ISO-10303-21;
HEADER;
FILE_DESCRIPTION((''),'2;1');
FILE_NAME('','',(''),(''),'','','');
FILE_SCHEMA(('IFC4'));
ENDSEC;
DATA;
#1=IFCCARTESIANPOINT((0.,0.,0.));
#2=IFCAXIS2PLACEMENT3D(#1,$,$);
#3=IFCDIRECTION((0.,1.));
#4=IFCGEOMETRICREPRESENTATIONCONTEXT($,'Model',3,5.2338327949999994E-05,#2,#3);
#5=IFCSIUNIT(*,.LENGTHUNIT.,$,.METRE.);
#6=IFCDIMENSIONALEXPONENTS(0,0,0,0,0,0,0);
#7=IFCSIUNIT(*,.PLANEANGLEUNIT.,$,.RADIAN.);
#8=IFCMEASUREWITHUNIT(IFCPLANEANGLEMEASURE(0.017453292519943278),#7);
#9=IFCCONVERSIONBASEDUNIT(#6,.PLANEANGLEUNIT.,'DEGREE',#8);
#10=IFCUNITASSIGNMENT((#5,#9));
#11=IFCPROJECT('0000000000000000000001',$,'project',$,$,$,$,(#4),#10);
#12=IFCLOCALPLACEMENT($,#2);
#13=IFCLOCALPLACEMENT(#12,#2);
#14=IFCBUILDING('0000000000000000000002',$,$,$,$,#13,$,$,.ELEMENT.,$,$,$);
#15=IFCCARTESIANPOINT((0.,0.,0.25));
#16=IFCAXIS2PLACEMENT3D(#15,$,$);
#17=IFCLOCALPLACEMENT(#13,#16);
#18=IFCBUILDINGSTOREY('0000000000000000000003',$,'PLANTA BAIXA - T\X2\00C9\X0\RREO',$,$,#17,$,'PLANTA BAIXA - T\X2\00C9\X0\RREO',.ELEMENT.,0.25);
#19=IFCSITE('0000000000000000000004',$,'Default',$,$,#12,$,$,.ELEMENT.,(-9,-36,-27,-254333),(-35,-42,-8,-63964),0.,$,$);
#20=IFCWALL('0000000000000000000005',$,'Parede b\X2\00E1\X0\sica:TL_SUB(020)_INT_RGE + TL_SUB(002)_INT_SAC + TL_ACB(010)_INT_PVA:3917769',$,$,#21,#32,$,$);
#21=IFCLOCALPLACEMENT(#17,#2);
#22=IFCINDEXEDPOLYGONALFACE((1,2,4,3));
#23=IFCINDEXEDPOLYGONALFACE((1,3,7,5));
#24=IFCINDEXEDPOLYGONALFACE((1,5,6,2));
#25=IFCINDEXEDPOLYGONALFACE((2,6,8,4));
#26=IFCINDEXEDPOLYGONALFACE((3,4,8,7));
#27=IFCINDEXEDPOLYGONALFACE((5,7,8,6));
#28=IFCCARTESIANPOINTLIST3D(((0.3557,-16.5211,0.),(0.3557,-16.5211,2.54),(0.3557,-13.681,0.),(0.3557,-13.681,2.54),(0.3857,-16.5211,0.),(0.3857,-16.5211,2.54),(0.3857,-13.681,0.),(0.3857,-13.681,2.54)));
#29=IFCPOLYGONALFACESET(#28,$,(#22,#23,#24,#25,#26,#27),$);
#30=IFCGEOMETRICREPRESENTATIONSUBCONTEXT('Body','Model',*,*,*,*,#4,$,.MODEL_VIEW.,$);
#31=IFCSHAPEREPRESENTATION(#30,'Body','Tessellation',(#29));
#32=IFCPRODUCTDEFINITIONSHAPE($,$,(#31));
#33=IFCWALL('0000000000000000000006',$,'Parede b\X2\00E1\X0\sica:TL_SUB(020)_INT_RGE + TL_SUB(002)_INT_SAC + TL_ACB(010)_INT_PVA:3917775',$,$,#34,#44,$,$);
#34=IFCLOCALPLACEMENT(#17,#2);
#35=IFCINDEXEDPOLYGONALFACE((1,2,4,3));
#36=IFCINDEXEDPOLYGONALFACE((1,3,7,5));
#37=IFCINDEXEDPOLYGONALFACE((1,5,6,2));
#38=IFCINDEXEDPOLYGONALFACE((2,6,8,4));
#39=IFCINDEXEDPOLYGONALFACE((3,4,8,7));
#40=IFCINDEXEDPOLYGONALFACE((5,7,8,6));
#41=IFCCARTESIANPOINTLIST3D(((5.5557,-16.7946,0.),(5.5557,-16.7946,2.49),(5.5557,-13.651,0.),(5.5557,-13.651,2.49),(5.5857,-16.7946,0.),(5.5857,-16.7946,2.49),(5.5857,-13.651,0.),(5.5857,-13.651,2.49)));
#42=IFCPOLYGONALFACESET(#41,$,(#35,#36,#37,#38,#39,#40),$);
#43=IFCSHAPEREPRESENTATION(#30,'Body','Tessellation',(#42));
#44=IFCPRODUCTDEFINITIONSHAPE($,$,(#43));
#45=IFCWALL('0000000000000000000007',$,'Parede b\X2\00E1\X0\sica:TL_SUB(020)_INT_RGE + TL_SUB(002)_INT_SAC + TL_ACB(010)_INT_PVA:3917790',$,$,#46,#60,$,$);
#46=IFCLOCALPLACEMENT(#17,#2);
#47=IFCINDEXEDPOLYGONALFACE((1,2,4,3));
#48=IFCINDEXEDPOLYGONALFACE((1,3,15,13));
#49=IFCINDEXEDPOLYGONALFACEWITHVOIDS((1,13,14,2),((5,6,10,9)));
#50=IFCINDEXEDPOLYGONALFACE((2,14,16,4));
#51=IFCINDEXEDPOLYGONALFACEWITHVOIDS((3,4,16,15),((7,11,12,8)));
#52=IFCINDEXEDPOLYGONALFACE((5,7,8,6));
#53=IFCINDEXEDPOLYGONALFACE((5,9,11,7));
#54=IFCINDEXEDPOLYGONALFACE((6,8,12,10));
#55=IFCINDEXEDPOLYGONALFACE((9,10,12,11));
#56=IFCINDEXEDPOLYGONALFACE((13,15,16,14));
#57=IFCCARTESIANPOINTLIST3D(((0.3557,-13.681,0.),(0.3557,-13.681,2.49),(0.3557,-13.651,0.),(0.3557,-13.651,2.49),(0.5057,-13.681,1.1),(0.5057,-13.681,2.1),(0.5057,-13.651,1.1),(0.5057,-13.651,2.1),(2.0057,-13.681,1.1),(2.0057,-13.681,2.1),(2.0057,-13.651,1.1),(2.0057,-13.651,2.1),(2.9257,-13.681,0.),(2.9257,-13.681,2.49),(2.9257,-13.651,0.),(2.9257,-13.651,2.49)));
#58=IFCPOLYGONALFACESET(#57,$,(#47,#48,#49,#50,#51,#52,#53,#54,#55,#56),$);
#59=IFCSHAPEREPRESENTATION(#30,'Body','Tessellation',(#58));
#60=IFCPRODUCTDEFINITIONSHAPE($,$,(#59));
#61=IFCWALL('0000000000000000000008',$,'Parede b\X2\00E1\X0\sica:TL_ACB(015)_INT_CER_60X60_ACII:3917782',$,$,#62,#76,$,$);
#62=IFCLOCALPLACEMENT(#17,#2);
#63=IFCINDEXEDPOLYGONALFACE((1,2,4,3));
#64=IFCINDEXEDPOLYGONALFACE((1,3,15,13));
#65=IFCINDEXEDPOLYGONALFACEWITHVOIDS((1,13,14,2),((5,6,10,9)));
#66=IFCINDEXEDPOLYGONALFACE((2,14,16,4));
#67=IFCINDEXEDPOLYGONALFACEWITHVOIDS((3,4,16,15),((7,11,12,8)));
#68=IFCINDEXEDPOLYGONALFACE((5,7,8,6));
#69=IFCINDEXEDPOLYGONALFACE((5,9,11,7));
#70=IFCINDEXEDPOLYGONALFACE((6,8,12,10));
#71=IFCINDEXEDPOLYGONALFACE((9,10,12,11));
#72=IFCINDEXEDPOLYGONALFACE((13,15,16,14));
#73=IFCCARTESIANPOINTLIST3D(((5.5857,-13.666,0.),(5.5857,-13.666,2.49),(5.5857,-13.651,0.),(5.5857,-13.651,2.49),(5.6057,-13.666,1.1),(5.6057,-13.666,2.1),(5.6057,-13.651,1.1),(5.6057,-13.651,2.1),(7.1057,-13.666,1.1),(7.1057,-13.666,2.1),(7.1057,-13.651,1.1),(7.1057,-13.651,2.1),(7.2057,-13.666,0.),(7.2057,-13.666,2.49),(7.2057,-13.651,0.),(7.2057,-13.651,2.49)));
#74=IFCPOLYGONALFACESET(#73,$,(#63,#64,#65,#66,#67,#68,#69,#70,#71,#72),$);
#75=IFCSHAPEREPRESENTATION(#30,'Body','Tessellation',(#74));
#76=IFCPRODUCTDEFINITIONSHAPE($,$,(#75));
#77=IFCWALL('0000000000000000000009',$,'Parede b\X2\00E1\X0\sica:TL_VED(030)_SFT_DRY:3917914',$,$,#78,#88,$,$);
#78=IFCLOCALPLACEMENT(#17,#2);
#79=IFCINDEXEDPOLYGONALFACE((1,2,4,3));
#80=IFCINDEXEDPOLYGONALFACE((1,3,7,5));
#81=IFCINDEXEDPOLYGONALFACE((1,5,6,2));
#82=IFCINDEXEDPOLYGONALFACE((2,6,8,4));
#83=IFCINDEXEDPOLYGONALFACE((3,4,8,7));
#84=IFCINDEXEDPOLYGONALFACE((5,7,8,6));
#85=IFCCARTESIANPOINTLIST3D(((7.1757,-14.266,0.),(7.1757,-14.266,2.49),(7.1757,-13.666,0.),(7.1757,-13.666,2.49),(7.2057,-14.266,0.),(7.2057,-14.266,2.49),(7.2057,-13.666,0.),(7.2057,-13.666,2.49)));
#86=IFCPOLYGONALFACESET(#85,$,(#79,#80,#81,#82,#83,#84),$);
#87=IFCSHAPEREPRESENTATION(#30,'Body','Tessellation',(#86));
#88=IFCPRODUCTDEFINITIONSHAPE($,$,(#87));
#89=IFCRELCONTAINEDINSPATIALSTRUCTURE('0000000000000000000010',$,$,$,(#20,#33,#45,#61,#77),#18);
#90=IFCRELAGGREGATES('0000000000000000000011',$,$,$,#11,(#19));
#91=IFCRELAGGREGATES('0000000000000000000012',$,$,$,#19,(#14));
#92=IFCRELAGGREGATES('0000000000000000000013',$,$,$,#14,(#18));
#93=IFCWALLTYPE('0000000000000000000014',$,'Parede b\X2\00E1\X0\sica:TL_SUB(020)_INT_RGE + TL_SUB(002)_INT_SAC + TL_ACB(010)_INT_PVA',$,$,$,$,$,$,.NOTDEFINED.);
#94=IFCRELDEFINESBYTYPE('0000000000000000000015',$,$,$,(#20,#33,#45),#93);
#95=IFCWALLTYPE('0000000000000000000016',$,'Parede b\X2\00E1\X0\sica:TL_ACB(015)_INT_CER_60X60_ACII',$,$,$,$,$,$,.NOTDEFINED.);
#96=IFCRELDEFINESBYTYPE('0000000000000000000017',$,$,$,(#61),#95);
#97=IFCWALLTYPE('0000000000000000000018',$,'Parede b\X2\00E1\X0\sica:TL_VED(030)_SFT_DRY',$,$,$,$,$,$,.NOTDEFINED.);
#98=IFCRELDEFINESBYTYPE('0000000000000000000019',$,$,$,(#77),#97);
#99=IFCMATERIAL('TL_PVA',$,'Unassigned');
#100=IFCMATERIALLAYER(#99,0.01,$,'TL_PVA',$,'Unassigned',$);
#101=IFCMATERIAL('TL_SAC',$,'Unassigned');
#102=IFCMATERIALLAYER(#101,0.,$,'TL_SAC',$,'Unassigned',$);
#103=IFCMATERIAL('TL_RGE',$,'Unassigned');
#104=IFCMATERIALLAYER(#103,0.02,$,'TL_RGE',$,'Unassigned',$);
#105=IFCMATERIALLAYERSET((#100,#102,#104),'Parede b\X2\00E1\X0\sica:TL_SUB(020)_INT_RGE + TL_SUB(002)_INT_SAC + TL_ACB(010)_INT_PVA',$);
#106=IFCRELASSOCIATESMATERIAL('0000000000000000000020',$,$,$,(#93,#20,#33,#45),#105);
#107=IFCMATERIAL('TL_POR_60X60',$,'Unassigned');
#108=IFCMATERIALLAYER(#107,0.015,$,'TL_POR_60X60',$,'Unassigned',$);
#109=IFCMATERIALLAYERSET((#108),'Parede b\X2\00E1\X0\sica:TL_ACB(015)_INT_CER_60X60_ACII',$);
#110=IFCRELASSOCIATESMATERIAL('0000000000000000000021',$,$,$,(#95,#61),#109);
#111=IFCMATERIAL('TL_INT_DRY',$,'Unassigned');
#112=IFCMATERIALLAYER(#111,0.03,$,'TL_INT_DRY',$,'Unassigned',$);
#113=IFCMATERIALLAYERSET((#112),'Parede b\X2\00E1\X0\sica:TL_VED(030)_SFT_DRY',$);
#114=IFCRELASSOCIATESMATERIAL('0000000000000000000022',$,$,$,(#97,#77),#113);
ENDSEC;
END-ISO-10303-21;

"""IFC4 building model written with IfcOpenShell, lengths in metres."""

from ifc_helpers import new_model, entity, si_unit, converted_unit, direction, frame, frame_2d, origin, place, context, subcontext, project, spatial, rectangle, extrude, material, layer, layer_set, layer_usage, type_object, element, save


model = new_model("IFC4")

# Units and contexts
model_context = context("Model", 3, precision=5.2338327949999994e-05, world=origin(), true_north=direction((0.0, 1.0)))
body_context = subcontext(model_context, "Body", "Model", "MODEL_VIEW")
ifc_project = project(units=[si_unit("LENGTHUNIT", "METRE"), converted_unit("PLANEANGLEUNIT", "DEGREE", entity("IfcPlaneAngleMeasure", 0.017453292519943278), si_unit("PLANEANGLEUNIT", "RADIAN"), dimensions=[0, 0, 0, 0, 0, 0, 0])], contexts=[model_context])

# Site, building, storey
site_placement = place(None, frame((0.0, 0.0, 0.0)))
site = spatial("IfcSite", under=ifc_project, at=site_placement, Name="Default", CompositionType="ELEMENT", RefLatitude=(-9, -36, -27, -254333), RefLongitude=(-35, -42, -8, -63964), RefElevation=0.0)
building_placement = place(site_placement, origin())
building = spatial("IfcBuilding", under=site, at=building_placement, CompositionType="ELEMENT")
storey_placement = place(building_placement, frame((0.0, 0.0, 0.25)))
storey = spatial("IfcBuildingStorey", under=building, at=storey_placement, Name="PLANTA BAIXA - TÉRREO", LongName="PLANTA BAIXA - TÉRREO", CompositionType="ELEMENT", Elevation=0.25)

# Walls
ifc_material_1 = material(Name="TL_PVA", Category="Unassigned")
ifc_layer_1 = layer(ifc_material_1, 0.01, Name="TL_PVA", Category="Unassigned")
ifc_material_2 = material(Name="TL_SAC", Category="Unassigned")
ifc_layer_2 = layer(ifc_material_2, 0.0, Name="TL_SAC", Category="Unassigned")
ifc_material_3 = material(Name="TL_RGE", Category="Unassigned")
ifc_layer_3 = layer(ifc_material_3, 0.02, Name="TL_RGE", Category="Unassigned")
ifc_layer_set_1 = layer_set([ifc_layer_1, ifc_layer_2, ifc_layer_3], Name="Parede básica:TL_SUB(020)_INT_RGE + TL_SUB(002)_INT_SAC + TL_ACB(010)_INT_PVA")
ifc_layer_usage_1 = layer_usage(ifc_layer_set_1, "AXIS2", "NEGATIVE", 0.015)
wall_type_1 = type_object("IfcWallType", Name="Parede básica:TL_SUB(020)_INT_RGE + TL_SUB(002)_INT_SAC + TL_ACB(010)_INT_PVA", PredefinedType="NOTDEFINED", material=ifc_layer_set_1)
wall_1_placement = place(storey_placement, frame((0.3707, -13.681, 0.0), z_axis=(0.0, 0.0, 1.0), x_axis=(0.0, -1.0, 0.0)))
element("IfcWall", 1, at=wall_1_placement, inside=storey, type_object=wall_type_1, material=ifc_layer_usage_1, Name="Parede básica:TL_SUB(020)_INT_RGE + TL_SUB(002)_INT_SAC + TL_ACB(010)_INT_PVA:3917769", context=body_context, shape_type="SweptSolid", body=[
    extrude(rectangle(XDim=2.8401, YDim=0.03, at=frame_2d((1.4201, 0.0), x_axis=(-1.0, 0.0))), origin(), (0.0, 0.0, 1.0), 2.54),
])
ifc_layer_usage_2 = layer_usage(ifc_layer_set_1, "AXIS2", "NEGATIVE", 0.015)
wall_2_placement = place(storey_placement, frame((5.5707, -13.651, 0.0), z_axis=(0.0, 0.0, 1.0), x_axis=(0.0, -1.0, 0.0)))
element("IfcWall", 2, at=wall_2_placement, inside=storey, type_object=wall_type_1, material=ifc_layer_usage_2, Name="Parede básica:TL_SUB(020)_INT_RGE + TL_SUB(002)_INT_SAC + TL_ACB(010)_INT_PVA:3917775", context=body_context, shape_type="SweptSolid", body=[
    extrude(rectangle(XDim=3.1437, YDim=0.03, at=frame_2d((1.5718, 0.0), x_axis=(-1.0, 0.0))), origin(), (0.0, 0.0, 1.0), 2.49),
])

# Walls, openings
ifc_layer_usage_3 = layer_usage(ifc_layer_set_1, "AXIS2", "NEGATIVE", 0.015)
wall_3_placement = place(storey_placement, frame((2.9257, -13.666, 0.0), z_axis=(0.0, 0.0, 1.0), x_axis=(-1.0, 0.0, 0.0)))
wall_3 = element("IfcWall", 3, at=wall_3_placement, inside=storey, type_object=wall_type_1, material=ifc_layer_usage_3, Name="Parede básica:TL_SUB(020)_INT_RGE + TL_SUB(002)_INT_SAC + TL_ACB(010)_INT_PVA:3917790", context=body_context, shape_type="SweptSolid", body=[
    extrude(rectangle(XDim=2.57, YDim=0.03, at=frame_2d((1.285, 0.0), x_axis=(-1.0, 0.0))), origin(), (0.0, 0.0, 1.0), 2.49),
])
opening_1_placement = place(wall_3_placement, frame((2.9257, -13.666, 1.1)))
element("IfcOpeningElement", 4, at=opening_1_placement, cuts=wall_3, PredefinedType="OPENING", context=body_context, shape_type="SweptSolid", body=[
    extrude(rectangle(XDim=1.0, YDim=1.5, at=frame_2d((0.0, 0.0), x_axis=(0.0, 1.0))), frame((-1.2557, 12.127, 0.5), z_axis=(0.0, 1.0, 0.0), x_axis=(1.0, 0.0, 0.0)), (0.0, 0.0, 1.0), 3.048),
])
ifc_material_4 = material(Name="TL_POR_60X60", Category="Unassigned")
ifc_layer_4 = layer(ifc_material_4, 0.015, Name="TL_POR_60X60", Category="Unassigned")
ifc_layer_set_2 = layer_set([ifc_layer_4], Name="Parede básica:TL_ACB(015)_INT_CER_60X60_ACII")
ifc_layer_usage_4 = layer_usage(ifc_layer_set_2, "AXIS2", "NEGATIVE", 0.0075)
wall_type_2 = type_object("IfcWallType", Name="Parede básica:TL_ACB(015)_INT_CER_60X60_ACII", PredefinedType="NOTDEFINED", material=ifc_layer_set_2)
wall_4_placement = place(storey_placement, frame((7.2057, -13.6585, 0.0), z_axis=(0.0, 0.0, 1.0), x_axis=(-1.0, 0.0, 0.0)))
wall_4 = element("IfcWall", 5, at=wall_4_placement, inside=storey, type_object=wall_type_2, material=ifc_layer_usage_4, Name="Parede básica:TL_ACB(015)_INT_CER_60X60_ACII:3917782", context=body_context, shape_type="SweptSolid", body=[
    extrude(rectangle(XDim=1.62, YDim=0.015, at=frame_2d((0.81, 0.0), x_axis=(-1.0, 0.0))), origin(), (0.0, 0.0, 1.0), 2.49),
])
opening_2_placement = place(wall_4_placement, frame((7.2057, -13.6585, 1.1)))
element("IfcOpeningElement", 6, at=opening_2_placement, cuts=wall_4, PredefinedType="OPENING", context=body_context, shape_type="SweptSolid", body=[
    extrude(rectangle(XDim=1.0, YDim=1.5, at=frame_2d((0.0, 0.0), x_axis=(0.0, 1.0))), frame((-6.3557, 12.127, 0.5), z_axis=(0.0, 1.0, 0.0), x_axis=(1.0, 0.0, 0.0)), (0.0, 0.0, 1.0), 3.048),
])

# Wall
ifc_material_5 = material(Name="TL_INT_DRY", Category="Unassigned")
ifc_layer_5 = layer(ifc_material_5, 0.03, Name="TL_INT_DRY", Category="Unassigned")
ifc_layer_set_3 = layer_set([ifc_layer_5], Name="Parede básica:TL_VED(030)_SFT_DRY")
ifc_layer_usage_5 = layer_usage(ifc_layer_set_3, "AXIS2", "POSITIVE", -0.015)
wall_type_3 = type_object("IfcWallType", Name="Parede básica:TL_VED(030)_SFT_DRY", PredefinedType="NOTDEFINED", material=ifc_layer_set_3)
wall_5_placement = place(storey_placement, frame((7.1907, -13.666, 0.0), z_axis=(0.0, 0.0, 1.0), x_axis=(0.0, -1.0, 0.0)))
element("IfcWall", 7, at=wall_5_placement, inside=storey, type_object=wall_type_3, material=ifc_layer_usage_5, Name="Parede básica:TL_VED(030)_SFT_DRY:3917914", context=body_context, shape_type="SweptSolid", body=[
    extrude(rectangle(XDim=0.6, YDim=0.03, at=frame_2d((0.3, 0.0), x_axis=(-1.0, 0.0))), origin(), (0.0, 0.0, 1.0), 2.49),
])

save(model, "model.ifc")
